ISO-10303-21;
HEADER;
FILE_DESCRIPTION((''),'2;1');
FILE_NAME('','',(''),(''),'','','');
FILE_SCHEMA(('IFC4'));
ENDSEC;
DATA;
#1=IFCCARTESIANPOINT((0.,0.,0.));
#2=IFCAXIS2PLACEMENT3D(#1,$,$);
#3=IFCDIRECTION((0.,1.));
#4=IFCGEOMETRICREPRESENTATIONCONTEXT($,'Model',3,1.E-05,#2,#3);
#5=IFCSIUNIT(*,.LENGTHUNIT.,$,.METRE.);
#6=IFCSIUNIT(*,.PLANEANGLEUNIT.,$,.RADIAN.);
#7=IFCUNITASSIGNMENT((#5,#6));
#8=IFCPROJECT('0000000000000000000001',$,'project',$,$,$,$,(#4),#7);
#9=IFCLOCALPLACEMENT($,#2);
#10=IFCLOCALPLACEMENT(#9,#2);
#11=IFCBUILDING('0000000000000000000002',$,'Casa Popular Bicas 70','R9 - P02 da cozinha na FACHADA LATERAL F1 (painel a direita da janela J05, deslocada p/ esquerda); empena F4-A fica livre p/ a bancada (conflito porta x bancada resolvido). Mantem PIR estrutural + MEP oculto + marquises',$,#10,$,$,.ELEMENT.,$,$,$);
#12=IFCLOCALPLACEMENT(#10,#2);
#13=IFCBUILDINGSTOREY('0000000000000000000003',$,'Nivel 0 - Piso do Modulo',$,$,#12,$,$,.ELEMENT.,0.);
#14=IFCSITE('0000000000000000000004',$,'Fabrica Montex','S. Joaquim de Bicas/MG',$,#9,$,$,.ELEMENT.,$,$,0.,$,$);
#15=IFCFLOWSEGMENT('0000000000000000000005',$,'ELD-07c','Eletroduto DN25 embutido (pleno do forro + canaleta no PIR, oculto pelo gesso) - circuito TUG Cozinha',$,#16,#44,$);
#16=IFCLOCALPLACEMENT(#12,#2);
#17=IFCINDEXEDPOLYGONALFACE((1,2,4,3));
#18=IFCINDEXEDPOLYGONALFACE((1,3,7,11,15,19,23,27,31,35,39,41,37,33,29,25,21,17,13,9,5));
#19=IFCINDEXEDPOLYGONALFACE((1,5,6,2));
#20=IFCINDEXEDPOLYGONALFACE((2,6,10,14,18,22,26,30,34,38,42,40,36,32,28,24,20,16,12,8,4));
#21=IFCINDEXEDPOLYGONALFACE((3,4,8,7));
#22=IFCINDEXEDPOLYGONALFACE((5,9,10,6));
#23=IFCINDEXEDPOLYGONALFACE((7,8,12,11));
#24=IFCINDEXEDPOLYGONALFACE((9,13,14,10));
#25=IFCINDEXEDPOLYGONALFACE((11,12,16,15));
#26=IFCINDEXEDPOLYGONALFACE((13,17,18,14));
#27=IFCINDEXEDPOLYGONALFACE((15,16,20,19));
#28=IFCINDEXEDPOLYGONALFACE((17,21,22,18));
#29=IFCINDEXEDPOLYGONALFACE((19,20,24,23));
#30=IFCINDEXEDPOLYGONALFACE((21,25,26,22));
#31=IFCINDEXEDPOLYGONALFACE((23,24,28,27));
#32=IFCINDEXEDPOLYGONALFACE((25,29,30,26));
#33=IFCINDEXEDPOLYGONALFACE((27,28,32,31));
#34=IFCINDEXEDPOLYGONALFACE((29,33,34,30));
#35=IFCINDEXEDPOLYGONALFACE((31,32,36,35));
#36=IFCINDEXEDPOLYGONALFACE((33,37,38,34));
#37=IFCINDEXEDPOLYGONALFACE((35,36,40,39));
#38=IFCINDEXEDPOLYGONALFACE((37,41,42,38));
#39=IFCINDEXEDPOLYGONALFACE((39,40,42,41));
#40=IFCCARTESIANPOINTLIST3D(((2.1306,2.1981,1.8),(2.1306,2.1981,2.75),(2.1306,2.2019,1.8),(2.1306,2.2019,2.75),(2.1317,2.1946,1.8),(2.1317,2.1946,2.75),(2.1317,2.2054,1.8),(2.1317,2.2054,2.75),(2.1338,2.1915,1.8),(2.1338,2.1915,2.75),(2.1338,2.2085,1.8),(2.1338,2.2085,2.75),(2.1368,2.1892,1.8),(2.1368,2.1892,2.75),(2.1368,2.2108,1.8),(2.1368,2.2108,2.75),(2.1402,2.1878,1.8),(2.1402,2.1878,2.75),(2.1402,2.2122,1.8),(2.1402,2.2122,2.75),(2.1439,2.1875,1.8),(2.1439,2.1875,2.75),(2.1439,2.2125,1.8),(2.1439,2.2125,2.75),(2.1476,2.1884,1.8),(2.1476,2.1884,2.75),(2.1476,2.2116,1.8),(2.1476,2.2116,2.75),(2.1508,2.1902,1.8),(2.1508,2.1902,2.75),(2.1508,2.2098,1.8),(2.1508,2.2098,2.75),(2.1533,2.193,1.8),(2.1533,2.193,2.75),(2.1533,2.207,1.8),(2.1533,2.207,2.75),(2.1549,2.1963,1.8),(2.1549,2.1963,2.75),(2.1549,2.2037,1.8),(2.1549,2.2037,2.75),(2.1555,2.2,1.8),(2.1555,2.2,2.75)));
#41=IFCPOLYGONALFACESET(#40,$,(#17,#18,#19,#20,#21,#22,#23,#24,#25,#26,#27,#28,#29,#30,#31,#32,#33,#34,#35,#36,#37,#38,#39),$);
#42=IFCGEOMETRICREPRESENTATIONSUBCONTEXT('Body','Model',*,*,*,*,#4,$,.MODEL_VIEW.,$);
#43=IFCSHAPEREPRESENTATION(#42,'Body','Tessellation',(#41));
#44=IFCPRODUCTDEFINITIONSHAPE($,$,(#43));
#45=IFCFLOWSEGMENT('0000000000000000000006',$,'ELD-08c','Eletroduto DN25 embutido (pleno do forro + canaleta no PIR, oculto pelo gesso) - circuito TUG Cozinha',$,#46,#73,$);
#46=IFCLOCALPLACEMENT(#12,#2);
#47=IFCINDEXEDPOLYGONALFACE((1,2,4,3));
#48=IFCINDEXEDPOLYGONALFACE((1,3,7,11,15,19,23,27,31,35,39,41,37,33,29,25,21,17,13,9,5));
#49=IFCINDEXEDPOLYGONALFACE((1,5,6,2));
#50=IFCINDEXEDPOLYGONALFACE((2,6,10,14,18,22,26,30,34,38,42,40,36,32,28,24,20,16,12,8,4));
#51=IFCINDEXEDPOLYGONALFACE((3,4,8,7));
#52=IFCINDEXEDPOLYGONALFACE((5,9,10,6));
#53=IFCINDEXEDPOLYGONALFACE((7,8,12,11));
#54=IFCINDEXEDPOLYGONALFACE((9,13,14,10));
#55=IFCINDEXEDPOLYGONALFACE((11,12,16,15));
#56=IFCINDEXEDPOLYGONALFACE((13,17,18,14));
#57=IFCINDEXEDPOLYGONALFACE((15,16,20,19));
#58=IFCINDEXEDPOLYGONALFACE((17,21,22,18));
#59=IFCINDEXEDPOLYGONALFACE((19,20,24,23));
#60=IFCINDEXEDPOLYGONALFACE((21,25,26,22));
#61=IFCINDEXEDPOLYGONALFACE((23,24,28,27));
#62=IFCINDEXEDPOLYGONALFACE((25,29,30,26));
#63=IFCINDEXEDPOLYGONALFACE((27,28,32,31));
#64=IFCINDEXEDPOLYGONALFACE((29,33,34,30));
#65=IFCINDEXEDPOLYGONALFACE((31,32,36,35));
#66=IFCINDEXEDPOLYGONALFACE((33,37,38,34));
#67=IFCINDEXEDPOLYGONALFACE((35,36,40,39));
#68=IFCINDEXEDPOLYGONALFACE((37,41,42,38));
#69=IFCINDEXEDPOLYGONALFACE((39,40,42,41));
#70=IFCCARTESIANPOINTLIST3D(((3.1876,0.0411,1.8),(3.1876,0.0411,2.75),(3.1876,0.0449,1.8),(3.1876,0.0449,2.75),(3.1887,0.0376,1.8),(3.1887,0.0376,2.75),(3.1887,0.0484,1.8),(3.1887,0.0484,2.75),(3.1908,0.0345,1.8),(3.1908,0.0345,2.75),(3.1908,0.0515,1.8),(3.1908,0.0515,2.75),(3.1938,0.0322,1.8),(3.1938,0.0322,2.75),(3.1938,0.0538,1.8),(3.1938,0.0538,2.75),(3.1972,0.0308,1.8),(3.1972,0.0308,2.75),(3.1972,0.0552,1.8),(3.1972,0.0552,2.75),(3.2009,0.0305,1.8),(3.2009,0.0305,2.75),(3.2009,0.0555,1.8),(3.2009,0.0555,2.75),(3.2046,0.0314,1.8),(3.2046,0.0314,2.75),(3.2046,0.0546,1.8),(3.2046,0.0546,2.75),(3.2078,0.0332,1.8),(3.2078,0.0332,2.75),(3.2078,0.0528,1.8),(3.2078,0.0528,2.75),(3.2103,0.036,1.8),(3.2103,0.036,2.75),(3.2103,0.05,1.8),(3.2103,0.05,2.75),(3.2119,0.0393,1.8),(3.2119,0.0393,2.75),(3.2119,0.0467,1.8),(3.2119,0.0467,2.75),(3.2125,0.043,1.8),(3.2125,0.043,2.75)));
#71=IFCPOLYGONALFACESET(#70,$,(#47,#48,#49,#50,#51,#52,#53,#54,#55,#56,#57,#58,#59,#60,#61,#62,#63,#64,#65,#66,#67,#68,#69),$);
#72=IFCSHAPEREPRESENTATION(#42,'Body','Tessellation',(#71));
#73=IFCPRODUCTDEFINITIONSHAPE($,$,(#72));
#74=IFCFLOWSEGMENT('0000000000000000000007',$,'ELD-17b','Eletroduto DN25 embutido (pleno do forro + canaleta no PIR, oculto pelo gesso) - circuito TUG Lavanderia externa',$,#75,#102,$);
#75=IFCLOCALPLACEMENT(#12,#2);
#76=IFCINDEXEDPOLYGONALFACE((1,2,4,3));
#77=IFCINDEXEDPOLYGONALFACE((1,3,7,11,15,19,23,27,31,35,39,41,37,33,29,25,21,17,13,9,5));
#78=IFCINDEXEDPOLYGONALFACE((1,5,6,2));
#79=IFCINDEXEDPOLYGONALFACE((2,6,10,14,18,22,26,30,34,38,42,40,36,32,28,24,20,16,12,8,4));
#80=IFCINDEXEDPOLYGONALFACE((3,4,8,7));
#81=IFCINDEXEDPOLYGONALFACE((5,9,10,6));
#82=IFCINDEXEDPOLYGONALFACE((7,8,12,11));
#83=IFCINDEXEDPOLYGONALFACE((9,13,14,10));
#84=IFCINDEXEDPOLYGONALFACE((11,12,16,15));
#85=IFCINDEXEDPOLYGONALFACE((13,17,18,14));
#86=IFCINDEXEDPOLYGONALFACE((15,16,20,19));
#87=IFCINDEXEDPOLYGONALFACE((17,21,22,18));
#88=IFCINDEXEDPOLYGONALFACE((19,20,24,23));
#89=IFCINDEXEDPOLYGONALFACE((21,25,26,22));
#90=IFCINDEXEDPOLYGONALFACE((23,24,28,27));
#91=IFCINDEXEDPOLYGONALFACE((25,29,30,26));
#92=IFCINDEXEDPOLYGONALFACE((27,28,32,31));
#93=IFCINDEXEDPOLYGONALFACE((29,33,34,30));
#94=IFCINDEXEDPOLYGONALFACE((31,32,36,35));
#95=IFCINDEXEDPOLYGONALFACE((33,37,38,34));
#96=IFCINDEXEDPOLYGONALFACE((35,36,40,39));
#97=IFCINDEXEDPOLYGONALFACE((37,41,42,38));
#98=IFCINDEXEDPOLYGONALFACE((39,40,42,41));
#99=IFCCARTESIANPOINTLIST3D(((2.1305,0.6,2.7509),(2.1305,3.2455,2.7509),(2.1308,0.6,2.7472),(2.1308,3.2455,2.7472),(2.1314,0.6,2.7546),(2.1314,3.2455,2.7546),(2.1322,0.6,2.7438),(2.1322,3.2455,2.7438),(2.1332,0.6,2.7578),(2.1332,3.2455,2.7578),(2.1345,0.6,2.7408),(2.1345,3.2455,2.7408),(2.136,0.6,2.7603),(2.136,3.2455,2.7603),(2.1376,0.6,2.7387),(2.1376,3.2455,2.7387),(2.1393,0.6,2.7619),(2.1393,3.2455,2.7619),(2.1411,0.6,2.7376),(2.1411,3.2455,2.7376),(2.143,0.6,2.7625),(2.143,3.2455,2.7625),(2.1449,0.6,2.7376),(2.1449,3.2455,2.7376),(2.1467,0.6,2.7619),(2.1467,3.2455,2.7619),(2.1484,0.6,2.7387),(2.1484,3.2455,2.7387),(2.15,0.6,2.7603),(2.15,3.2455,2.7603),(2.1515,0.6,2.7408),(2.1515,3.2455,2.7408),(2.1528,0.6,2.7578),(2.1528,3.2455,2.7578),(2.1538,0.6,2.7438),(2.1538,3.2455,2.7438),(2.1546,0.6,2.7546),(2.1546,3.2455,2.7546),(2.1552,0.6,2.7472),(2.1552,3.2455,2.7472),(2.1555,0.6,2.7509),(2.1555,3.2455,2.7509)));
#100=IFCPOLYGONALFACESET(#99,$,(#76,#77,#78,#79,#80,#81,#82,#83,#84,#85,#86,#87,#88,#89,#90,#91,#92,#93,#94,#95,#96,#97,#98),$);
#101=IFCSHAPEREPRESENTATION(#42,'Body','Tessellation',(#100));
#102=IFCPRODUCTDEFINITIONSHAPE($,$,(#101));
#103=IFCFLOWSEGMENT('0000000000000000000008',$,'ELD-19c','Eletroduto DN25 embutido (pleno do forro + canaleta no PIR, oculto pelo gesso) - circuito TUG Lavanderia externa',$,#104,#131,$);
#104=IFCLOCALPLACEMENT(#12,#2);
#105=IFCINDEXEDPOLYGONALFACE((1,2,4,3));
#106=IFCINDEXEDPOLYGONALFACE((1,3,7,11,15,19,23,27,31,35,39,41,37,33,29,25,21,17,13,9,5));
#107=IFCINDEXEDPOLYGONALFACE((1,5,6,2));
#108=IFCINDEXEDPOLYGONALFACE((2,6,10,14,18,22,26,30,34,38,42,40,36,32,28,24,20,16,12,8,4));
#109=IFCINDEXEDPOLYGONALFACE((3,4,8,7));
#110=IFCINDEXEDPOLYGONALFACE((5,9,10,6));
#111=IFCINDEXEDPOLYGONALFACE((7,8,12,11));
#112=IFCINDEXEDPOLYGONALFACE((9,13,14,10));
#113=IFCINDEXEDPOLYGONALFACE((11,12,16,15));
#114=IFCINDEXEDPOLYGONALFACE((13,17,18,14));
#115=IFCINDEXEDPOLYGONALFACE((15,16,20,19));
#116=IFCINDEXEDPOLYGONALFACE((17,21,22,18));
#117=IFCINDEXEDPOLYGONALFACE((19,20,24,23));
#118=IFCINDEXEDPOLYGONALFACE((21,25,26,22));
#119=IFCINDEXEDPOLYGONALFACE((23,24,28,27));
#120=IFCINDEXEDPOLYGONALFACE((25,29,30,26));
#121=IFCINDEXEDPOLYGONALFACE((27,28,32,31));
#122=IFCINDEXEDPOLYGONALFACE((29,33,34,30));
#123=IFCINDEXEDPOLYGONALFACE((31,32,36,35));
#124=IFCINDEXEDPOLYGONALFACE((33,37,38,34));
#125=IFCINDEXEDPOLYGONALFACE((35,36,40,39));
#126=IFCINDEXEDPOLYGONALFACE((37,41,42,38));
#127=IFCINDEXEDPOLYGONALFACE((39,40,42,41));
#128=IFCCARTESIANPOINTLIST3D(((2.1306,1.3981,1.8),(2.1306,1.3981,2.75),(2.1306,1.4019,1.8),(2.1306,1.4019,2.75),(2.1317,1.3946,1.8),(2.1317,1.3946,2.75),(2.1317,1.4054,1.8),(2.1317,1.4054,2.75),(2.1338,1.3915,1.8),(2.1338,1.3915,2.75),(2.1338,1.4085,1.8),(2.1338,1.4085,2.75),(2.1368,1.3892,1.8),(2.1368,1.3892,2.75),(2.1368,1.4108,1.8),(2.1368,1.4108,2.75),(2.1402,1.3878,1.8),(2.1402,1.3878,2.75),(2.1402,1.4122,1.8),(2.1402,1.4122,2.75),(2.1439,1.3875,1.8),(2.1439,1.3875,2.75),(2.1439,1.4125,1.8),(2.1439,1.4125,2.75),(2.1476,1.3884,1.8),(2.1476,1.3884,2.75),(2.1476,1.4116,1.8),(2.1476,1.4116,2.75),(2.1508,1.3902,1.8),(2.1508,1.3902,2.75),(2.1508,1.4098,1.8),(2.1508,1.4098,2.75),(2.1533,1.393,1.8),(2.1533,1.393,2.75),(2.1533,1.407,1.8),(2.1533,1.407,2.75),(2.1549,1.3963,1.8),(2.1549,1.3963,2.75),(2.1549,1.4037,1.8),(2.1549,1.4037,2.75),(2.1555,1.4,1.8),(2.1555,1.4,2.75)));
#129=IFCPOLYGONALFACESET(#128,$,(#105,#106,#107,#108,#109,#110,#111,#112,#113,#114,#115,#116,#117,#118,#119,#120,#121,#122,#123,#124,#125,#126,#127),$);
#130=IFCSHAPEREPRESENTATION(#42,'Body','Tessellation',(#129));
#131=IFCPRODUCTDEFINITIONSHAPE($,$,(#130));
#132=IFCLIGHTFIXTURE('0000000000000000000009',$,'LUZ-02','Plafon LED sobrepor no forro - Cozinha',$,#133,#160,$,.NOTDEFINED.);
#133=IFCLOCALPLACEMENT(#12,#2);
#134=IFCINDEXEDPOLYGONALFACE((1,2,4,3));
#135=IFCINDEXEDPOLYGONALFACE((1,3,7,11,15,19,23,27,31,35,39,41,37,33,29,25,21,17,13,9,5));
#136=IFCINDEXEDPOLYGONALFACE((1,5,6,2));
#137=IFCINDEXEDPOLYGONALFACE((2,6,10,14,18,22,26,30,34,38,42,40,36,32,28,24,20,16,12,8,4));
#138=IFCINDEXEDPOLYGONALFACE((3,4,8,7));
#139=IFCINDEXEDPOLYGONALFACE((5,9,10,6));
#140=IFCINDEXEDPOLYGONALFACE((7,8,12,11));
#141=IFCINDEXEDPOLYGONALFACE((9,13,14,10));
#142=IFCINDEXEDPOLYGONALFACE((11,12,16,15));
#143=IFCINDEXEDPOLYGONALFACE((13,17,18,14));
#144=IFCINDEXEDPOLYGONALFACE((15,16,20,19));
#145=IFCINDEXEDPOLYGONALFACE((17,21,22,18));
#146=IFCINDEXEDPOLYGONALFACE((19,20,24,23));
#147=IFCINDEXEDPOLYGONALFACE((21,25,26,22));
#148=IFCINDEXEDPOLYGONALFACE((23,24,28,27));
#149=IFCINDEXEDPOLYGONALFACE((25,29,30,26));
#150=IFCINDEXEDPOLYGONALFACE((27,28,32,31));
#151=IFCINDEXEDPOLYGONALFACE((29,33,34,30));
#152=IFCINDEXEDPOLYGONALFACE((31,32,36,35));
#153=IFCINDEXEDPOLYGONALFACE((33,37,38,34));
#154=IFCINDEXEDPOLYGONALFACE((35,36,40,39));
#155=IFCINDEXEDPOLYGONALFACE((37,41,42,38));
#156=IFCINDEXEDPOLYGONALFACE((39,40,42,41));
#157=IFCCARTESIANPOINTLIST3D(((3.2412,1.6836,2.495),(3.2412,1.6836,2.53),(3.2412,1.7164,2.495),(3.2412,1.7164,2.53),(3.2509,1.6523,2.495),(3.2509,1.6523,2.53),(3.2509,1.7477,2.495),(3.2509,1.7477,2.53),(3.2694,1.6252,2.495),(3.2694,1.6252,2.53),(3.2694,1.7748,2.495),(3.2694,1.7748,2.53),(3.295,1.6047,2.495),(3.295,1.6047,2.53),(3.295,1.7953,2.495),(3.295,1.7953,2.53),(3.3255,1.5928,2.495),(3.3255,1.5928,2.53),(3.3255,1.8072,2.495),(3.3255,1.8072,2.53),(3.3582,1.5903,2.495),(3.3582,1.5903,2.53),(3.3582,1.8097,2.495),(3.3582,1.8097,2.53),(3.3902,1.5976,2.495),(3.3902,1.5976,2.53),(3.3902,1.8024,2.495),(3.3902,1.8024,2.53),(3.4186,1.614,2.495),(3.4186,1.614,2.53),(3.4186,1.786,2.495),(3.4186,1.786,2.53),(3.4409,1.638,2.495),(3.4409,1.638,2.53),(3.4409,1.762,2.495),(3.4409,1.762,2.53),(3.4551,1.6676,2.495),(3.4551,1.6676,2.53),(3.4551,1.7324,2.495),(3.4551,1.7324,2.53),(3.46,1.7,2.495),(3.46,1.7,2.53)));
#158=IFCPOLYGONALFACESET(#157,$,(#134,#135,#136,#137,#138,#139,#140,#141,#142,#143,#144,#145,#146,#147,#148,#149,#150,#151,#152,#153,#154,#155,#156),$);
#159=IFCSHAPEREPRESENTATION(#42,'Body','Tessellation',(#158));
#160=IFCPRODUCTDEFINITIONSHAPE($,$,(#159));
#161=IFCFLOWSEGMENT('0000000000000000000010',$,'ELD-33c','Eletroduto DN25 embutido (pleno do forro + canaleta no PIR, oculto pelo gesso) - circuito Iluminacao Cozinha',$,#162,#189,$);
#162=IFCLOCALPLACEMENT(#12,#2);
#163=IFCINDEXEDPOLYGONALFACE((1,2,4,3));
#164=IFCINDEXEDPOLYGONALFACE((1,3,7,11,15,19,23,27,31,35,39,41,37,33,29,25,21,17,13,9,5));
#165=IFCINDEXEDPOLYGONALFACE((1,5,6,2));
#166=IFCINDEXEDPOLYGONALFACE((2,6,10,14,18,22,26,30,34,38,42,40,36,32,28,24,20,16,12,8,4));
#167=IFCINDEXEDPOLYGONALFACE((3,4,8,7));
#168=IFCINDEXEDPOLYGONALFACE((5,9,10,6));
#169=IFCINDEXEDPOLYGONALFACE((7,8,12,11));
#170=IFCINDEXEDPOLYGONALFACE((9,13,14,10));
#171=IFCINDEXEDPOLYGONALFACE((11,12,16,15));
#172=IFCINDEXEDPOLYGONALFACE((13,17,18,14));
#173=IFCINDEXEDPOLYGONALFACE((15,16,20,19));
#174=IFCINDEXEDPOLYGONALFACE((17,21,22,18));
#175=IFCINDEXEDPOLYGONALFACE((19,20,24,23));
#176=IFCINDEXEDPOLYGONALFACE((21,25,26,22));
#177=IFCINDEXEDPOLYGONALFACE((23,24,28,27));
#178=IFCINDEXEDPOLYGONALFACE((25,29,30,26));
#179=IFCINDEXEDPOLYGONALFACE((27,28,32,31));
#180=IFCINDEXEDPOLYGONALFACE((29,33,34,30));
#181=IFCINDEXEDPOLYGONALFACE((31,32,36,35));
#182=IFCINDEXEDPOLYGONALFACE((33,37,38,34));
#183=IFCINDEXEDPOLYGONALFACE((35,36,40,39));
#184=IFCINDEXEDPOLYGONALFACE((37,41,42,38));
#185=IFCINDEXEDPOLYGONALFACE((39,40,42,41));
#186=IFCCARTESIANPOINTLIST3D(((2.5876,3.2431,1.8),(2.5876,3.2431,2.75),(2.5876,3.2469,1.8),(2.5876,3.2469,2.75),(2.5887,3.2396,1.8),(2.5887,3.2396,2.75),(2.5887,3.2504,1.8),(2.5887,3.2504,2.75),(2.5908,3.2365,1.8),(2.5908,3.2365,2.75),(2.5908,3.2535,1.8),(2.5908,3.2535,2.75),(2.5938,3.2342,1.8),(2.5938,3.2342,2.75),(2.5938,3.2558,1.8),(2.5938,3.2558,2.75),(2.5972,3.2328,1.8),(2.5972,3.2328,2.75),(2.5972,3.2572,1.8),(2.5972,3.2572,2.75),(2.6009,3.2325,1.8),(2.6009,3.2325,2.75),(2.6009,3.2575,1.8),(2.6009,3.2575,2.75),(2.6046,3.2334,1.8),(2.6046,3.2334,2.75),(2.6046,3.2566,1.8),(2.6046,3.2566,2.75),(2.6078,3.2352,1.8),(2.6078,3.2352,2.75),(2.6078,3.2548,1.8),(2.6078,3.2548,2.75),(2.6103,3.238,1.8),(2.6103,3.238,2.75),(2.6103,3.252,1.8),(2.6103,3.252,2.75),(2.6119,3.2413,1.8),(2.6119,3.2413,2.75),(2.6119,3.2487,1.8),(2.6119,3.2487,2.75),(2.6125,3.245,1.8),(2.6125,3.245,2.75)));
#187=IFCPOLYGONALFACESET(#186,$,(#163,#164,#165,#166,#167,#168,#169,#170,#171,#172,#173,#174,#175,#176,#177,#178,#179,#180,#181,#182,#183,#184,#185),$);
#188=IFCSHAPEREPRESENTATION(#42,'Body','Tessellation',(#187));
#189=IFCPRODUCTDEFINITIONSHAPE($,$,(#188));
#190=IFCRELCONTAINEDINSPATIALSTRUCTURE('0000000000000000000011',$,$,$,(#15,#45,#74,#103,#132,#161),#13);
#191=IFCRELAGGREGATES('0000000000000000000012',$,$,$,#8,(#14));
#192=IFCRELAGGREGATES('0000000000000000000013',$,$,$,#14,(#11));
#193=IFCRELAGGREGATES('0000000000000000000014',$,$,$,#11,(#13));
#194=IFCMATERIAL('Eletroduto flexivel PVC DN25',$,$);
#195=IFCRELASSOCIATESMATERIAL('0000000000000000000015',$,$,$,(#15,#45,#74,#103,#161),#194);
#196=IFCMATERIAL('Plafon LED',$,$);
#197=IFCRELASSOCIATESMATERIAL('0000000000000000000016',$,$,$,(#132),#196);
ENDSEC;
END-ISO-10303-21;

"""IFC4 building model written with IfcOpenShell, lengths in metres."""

from ifc_helpers import new_model, si_unit, direction, frame, origin, origin_2d, place, context, subcontext, project, spatial, circle, extrude, material, element, save


model = new_model("IFC4")

# Units and contexts
model_context = context("Model", 3, precision=1e-05, world=origin(), true_north=direction((0.0, 1.0)))
body_context = subcontext(model_context, "Body", "Model", "MODEL_VIEW")
ifc_project = project(units=[si_unit("LENGTHUNIT", "METRE"), si_unit("PLANEANGLEUNIT", "RADIAN")], contexts=[model_context])

# Site, building, storey
site_placement = place(None, origin())
site = spatial("IfcSite", under=ifc_project, at=site_placement, Name="Fabrica Montex", Description="S. Joaquim de Bicas/MG", CompositionType="ELEMENT", RefElevation=0.0)
building_placement = place(site_placement, origin())
building = spatial("IfcBuilding", under=site, at=building_placement, Name="Casa Popular Bicas 70", Description="R9 - P02 da cozinha na FACHADA LATERAL F1 (painel a direita da janela J05, deslocada p/ esquerda); empena F4-A fica livre p/ a bancada (conflito porta x bancada resolvido). Mantem PIR estrutural + MEP oculto + marquises", CompositionType="ELEMENT")
storey_placement = place(building_placement, origin())
storey = spatial("IfcBuildingStorey", under=building, at=storey_placement, Name="Nivel 0 - Piso do Modulo", CompositionType="ELEMENT", Elevation=0.0)

# Flow segments
ifc_material_1 = material(Name="Eletroduto flexivel PVC DN25")
for number, where, z_axis, x_axis, name in (
    (1, (2.143, 2.2, 2.75), (0.0, 0.0, -1.0), (1.0, 0.0, 0.0), "ELD-07c"),
    (2, (3.2, 0.043, 2.75), (0.0, 0.0, -1.0), (1.0, 0.0, 0.0), "ELD-08c"),
):
    element("IfcFlowSegment", number, at=place(storey_placement, frame(where, z_axis=z_axis, x_axis=x_axis)), inside=storey, material=ifc_material_1, Name=name, Description="Eletroduto DN25 embutido (pleno do forro + canaleta no PIR, oculto pelo gesso) - circuito TUG Cozinha", context=body_context, shape_type="SweptSolid", body=[
        extrude(circle(Radius=0.0125, at=origin_2d()), origin(), (0.0, 0.0, 1.0), 0.95),
    ])
flow_segment_1_placement = place(storey_placement, frame((2.143, 3.2455, 2.75), z_axis=(0.0, -1.0, 0.0), x_axis=(0.0, 0.0, 1.0)))
element("IfcFlowSegment", 3, at=flow_segment_1_placement, inside=storey, material=ifc_material_1, Name="ELD-17b", Description="Eletroduto DN25 embutido (pleno do forro + canaleta no PIR, oculto pelo gesso) - circuito TUG Lavanderia externa", context=body_context, shape_type="SweptSolid", body=[
    extrude(circle(Radius=0.0125, at=origin_2d()), origin(), (0.0, 0.0, 1.0), 2.6455),
])
for number, where, z_axis, x_axis, name in (
    (4, (2.143, 1.4, 2.75), (0.0, 0.0, -1.0), (1.0, 0.0, 0.0), "ELD-19c"),
):
    element("IfcFlowSegment", number, at=place(storey_placement, frame(where, z_axis=z_axis, x_axis=x_axis)), inside=storey, material=ifc_material_1, Name=name, Description="Eletroduto DN25 embutido (pleno do forro + canaleta no PIR, oculto pelo gesso) - circuito TUG Lavanderia externa", context=body_context, shape_type="SweptSolid", body=[
        extrude(circle(Radius=0.0125, at=origin_2d()), origin(), (0.0, 0.0, 1.0), 0.95),
    ])

# Light fixture
ifc_material_2 = material(Name="Plafon LED")
light_fixture_placement = place(storey_placement, frame((3.35, 1.7, 2.495)))
element("IfcLightFixture", 5, at=light_fixture_placement, inside=storey, material=ifc_material_2, Name="LUZ-02", Description="Plafon LED sobrepor no forro - Cozinha", PredefinedType="NOTDEFINED", context=body_context, shape_type="SweptSolid", body=[
    extrude(circle(Radius=0.11, at=origin_2d()), origin(), (0.0, 0.0, 1.0), 0.035),
])

# Flow segment
flow_segment_2_placement = place(storey_placement, frame((2.6, 3.245, 2.75), z_axis=(0.0, 0.0, -1.0), x_axis=(1.0, 0.0, 0.0)))
element("IfcFlowSegment", 6, at=flow_segment_2_placement, inside=storey, material=ifc_material_1, Name="ELD-33c", Description="Eletroduto DN25 embutido (pleno do forro + canaleta no PIR, oculto pelo gesso) - circuito Iluminacao Cozinha", context=body_context, shape_type="SweptSolid", body=[
    extrude(circle(Radius=0.0125, at=origin_2d()), origin(), (0.0, 0.0, 1.0), 0.95),
])

save(model, "model.ifc")
